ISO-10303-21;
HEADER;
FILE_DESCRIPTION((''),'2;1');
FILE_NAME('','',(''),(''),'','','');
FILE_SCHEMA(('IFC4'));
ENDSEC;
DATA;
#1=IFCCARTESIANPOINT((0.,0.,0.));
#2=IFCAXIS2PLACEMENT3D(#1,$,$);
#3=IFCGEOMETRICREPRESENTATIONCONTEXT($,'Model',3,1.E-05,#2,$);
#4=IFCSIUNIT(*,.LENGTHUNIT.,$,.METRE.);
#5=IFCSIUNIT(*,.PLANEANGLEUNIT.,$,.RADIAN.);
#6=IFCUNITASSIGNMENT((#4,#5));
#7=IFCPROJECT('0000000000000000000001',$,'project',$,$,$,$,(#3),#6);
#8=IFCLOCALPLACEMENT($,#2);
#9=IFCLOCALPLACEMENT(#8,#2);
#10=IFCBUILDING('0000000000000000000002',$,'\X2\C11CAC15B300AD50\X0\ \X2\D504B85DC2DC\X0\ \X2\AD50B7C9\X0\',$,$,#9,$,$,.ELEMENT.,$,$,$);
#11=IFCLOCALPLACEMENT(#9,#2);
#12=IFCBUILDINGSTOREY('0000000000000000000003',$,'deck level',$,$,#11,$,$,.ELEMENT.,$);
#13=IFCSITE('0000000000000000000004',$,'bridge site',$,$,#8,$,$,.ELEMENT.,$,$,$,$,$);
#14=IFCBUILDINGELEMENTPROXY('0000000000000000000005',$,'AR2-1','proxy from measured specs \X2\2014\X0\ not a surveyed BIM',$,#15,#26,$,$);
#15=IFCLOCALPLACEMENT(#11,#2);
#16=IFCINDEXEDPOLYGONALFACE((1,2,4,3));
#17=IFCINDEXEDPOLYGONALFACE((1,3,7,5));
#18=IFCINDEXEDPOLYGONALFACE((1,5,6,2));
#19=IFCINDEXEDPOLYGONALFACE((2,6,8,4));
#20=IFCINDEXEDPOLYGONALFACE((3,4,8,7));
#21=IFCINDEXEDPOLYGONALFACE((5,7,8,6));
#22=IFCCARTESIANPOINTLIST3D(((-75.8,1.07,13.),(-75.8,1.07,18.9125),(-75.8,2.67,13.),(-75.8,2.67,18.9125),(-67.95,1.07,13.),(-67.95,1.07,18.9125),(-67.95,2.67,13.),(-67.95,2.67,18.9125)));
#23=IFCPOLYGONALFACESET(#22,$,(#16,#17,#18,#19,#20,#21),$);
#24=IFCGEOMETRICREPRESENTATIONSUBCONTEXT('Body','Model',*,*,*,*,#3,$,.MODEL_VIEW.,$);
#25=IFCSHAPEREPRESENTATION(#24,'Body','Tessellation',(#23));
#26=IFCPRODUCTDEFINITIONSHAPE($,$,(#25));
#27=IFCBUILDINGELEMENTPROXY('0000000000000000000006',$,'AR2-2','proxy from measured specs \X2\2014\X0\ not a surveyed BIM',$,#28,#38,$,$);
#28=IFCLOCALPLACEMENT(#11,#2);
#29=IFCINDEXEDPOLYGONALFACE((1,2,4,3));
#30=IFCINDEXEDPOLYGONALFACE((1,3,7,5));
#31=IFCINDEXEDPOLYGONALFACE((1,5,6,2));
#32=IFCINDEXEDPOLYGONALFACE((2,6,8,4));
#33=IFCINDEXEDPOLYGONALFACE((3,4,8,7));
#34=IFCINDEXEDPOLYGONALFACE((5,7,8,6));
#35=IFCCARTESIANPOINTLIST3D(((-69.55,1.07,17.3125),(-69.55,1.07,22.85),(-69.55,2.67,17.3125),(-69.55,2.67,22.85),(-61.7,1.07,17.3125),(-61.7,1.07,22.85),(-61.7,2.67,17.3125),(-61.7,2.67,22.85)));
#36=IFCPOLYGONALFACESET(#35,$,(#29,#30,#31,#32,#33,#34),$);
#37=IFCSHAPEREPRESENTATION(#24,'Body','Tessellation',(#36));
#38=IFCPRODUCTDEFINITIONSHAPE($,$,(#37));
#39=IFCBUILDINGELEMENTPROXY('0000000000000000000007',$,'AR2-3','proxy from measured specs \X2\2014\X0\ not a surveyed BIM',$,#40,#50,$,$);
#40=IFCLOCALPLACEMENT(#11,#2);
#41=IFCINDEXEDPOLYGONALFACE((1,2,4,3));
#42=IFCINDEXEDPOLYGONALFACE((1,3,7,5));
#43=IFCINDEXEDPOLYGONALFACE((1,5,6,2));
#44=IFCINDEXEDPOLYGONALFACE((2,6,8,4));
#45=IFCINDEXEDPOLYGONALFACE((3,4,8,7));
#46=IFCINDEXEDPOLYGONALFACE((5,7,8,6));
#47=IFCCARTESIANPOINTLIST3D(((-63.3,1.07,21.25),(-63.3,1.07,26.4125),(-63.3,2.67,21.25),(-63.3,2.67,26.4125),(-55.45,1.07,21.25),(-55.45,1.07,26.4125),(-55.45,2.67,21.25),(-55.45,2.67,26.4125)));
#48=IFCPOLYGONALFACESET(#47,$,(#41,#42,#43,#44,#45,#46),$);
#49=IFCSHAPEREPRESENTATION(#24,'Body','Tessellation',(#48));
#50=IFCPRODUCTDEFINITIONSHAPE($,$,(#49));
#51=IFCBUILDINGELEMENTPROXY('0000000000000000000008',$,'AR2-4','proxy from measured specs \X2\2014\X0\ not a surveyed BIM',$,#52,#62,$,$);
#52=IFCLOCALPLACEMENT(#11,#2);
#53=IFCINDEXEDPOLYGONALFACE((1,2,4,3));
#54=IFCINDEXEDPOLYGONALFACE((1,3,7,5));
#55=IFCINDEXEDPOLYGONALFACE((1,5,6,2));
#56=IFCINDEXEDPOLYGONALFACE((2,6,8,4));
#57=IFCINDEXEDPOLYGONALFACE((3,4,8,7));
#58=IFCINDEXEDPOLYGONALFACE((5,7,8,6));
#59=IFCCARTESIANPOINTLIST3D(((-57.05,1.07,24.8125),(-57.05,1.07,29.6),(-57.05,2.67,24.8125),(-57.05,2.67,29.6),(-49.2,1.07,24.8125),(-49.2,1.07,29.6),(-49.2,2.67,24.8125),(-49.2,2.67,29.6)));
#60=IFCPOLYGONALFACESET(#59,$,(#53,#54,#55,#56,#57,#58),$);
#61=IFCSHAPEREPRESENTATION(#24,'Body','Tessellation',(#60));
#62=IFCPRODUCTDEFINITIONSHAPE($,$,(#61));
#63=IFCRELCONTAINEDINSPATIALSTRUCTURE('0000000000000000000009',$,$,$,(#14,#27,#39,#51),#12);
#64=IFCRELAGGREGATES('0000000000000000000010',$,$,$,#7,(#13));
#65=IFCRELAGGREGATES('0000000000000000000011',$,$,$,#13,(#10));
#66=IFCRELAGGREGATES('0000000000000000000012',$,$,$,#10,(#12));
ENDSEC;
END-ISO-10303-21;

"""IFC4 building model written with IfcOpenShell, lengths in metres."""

from ifc_helpers import new_model, si_unit, frame, origin, origin_2d, place, context, subcontext, project, spatial, rectangle, extrude, element, save


model = new_model("IFC4")

# Units and contexts
model_context = context("Model", 3, precision=1e-05, world=origin())
body_context = subcontext(model_context, "Body", "Model", "MODEL_VIEW")
ifc_project = project(units=[si_unit("LENGTHUNIT", "METRE"), si_unit("PLANEANGLEUNIT", "RADIAN")], contexts=[model_context])

# Site, building, storey
site_placement = place(None, origin())
site = spatial("IfcSite", under=ifc_project, at=site_placement, Name="bridge site", CompositionType="ELEMENT")
building_placement = place(site_placement, origin())
building = spatial("IfcBuilding", under=site, at=building_placement, Name="서강대교 프록시 교량", CompositionType="ELEMENT")
storey_placement = place(building_placement, origin())
storey = spatial("IfcBuildingStorey", under=building, at=storey_placement, Name="deck level", CompositionType="ELEMENT")

# Building element proxies
proxy_1_placement = place(storey_placement, frame((-71.875, 1.87, 13.0)))
element("IfcBuildingElementProxy", 1, at=proxy_1_placement, inside=storey, Name="AR2-1", Description="proxy from measured specs — not a surveyed BIM", context=body_context, shape_type="SweptSolid", body=[
    extrude(rectangle(XDim=7.85, YDim=1.6, at=origin_2d()), origin(), (0.0, 0.0, 1.0), 5.9125),
])
proxy_2_placement = place(storey_placement, frame((-65.625, 1.87, 17.3125)))
element("IfcBuildingElementProxy", 2, at=proxy_2_placement, inside=storey, Name="AR2-2", Description="proxy from measured specs — not a surveyed BIM", context=body_context, shape_type="SweptSolid", body=[
    extrude(rectangle(XDim=7.85, YDim=1.6, at=origin_2d()), origin(), (0.0, 0.0, 1.0), 5.5375),
])
proxy_3_placement = place(storey_placement, frame((-59.375, 1.87, 21.25)))
element("IfcBuildingElementProxy", 3, at=proxy_3_placement, inside=storey, Name="AR2-3", Description="proxy from measured specs — not a surveyed BIM", context=body_context, shape_type="SweptSolid", body=[
    extrude(rectangle(XDim=7.85, YDim=1.6, at=origin_2d()), origin(), (0.0, 0.0, 1.0), 5.1625),
])
proxy_4_placement = place(storey_placement, frame((-53.125, 1.87, 24.8125)))
element("IfcBuildingElementProxy", 4, at=proxy_4_placement, inside=storey, Name="AR2-4", Description="proxy from measured specs — not a surveyed BIM", context=body_context, shape_type="SweptSolid", body=[
    extrude(rectangle(XDim=7.85, YDim=1.6, at=origin_2d()), origin(), (0.0, 0.0, 1.0), 4.7875),
])

save(model, "model.ifc")
